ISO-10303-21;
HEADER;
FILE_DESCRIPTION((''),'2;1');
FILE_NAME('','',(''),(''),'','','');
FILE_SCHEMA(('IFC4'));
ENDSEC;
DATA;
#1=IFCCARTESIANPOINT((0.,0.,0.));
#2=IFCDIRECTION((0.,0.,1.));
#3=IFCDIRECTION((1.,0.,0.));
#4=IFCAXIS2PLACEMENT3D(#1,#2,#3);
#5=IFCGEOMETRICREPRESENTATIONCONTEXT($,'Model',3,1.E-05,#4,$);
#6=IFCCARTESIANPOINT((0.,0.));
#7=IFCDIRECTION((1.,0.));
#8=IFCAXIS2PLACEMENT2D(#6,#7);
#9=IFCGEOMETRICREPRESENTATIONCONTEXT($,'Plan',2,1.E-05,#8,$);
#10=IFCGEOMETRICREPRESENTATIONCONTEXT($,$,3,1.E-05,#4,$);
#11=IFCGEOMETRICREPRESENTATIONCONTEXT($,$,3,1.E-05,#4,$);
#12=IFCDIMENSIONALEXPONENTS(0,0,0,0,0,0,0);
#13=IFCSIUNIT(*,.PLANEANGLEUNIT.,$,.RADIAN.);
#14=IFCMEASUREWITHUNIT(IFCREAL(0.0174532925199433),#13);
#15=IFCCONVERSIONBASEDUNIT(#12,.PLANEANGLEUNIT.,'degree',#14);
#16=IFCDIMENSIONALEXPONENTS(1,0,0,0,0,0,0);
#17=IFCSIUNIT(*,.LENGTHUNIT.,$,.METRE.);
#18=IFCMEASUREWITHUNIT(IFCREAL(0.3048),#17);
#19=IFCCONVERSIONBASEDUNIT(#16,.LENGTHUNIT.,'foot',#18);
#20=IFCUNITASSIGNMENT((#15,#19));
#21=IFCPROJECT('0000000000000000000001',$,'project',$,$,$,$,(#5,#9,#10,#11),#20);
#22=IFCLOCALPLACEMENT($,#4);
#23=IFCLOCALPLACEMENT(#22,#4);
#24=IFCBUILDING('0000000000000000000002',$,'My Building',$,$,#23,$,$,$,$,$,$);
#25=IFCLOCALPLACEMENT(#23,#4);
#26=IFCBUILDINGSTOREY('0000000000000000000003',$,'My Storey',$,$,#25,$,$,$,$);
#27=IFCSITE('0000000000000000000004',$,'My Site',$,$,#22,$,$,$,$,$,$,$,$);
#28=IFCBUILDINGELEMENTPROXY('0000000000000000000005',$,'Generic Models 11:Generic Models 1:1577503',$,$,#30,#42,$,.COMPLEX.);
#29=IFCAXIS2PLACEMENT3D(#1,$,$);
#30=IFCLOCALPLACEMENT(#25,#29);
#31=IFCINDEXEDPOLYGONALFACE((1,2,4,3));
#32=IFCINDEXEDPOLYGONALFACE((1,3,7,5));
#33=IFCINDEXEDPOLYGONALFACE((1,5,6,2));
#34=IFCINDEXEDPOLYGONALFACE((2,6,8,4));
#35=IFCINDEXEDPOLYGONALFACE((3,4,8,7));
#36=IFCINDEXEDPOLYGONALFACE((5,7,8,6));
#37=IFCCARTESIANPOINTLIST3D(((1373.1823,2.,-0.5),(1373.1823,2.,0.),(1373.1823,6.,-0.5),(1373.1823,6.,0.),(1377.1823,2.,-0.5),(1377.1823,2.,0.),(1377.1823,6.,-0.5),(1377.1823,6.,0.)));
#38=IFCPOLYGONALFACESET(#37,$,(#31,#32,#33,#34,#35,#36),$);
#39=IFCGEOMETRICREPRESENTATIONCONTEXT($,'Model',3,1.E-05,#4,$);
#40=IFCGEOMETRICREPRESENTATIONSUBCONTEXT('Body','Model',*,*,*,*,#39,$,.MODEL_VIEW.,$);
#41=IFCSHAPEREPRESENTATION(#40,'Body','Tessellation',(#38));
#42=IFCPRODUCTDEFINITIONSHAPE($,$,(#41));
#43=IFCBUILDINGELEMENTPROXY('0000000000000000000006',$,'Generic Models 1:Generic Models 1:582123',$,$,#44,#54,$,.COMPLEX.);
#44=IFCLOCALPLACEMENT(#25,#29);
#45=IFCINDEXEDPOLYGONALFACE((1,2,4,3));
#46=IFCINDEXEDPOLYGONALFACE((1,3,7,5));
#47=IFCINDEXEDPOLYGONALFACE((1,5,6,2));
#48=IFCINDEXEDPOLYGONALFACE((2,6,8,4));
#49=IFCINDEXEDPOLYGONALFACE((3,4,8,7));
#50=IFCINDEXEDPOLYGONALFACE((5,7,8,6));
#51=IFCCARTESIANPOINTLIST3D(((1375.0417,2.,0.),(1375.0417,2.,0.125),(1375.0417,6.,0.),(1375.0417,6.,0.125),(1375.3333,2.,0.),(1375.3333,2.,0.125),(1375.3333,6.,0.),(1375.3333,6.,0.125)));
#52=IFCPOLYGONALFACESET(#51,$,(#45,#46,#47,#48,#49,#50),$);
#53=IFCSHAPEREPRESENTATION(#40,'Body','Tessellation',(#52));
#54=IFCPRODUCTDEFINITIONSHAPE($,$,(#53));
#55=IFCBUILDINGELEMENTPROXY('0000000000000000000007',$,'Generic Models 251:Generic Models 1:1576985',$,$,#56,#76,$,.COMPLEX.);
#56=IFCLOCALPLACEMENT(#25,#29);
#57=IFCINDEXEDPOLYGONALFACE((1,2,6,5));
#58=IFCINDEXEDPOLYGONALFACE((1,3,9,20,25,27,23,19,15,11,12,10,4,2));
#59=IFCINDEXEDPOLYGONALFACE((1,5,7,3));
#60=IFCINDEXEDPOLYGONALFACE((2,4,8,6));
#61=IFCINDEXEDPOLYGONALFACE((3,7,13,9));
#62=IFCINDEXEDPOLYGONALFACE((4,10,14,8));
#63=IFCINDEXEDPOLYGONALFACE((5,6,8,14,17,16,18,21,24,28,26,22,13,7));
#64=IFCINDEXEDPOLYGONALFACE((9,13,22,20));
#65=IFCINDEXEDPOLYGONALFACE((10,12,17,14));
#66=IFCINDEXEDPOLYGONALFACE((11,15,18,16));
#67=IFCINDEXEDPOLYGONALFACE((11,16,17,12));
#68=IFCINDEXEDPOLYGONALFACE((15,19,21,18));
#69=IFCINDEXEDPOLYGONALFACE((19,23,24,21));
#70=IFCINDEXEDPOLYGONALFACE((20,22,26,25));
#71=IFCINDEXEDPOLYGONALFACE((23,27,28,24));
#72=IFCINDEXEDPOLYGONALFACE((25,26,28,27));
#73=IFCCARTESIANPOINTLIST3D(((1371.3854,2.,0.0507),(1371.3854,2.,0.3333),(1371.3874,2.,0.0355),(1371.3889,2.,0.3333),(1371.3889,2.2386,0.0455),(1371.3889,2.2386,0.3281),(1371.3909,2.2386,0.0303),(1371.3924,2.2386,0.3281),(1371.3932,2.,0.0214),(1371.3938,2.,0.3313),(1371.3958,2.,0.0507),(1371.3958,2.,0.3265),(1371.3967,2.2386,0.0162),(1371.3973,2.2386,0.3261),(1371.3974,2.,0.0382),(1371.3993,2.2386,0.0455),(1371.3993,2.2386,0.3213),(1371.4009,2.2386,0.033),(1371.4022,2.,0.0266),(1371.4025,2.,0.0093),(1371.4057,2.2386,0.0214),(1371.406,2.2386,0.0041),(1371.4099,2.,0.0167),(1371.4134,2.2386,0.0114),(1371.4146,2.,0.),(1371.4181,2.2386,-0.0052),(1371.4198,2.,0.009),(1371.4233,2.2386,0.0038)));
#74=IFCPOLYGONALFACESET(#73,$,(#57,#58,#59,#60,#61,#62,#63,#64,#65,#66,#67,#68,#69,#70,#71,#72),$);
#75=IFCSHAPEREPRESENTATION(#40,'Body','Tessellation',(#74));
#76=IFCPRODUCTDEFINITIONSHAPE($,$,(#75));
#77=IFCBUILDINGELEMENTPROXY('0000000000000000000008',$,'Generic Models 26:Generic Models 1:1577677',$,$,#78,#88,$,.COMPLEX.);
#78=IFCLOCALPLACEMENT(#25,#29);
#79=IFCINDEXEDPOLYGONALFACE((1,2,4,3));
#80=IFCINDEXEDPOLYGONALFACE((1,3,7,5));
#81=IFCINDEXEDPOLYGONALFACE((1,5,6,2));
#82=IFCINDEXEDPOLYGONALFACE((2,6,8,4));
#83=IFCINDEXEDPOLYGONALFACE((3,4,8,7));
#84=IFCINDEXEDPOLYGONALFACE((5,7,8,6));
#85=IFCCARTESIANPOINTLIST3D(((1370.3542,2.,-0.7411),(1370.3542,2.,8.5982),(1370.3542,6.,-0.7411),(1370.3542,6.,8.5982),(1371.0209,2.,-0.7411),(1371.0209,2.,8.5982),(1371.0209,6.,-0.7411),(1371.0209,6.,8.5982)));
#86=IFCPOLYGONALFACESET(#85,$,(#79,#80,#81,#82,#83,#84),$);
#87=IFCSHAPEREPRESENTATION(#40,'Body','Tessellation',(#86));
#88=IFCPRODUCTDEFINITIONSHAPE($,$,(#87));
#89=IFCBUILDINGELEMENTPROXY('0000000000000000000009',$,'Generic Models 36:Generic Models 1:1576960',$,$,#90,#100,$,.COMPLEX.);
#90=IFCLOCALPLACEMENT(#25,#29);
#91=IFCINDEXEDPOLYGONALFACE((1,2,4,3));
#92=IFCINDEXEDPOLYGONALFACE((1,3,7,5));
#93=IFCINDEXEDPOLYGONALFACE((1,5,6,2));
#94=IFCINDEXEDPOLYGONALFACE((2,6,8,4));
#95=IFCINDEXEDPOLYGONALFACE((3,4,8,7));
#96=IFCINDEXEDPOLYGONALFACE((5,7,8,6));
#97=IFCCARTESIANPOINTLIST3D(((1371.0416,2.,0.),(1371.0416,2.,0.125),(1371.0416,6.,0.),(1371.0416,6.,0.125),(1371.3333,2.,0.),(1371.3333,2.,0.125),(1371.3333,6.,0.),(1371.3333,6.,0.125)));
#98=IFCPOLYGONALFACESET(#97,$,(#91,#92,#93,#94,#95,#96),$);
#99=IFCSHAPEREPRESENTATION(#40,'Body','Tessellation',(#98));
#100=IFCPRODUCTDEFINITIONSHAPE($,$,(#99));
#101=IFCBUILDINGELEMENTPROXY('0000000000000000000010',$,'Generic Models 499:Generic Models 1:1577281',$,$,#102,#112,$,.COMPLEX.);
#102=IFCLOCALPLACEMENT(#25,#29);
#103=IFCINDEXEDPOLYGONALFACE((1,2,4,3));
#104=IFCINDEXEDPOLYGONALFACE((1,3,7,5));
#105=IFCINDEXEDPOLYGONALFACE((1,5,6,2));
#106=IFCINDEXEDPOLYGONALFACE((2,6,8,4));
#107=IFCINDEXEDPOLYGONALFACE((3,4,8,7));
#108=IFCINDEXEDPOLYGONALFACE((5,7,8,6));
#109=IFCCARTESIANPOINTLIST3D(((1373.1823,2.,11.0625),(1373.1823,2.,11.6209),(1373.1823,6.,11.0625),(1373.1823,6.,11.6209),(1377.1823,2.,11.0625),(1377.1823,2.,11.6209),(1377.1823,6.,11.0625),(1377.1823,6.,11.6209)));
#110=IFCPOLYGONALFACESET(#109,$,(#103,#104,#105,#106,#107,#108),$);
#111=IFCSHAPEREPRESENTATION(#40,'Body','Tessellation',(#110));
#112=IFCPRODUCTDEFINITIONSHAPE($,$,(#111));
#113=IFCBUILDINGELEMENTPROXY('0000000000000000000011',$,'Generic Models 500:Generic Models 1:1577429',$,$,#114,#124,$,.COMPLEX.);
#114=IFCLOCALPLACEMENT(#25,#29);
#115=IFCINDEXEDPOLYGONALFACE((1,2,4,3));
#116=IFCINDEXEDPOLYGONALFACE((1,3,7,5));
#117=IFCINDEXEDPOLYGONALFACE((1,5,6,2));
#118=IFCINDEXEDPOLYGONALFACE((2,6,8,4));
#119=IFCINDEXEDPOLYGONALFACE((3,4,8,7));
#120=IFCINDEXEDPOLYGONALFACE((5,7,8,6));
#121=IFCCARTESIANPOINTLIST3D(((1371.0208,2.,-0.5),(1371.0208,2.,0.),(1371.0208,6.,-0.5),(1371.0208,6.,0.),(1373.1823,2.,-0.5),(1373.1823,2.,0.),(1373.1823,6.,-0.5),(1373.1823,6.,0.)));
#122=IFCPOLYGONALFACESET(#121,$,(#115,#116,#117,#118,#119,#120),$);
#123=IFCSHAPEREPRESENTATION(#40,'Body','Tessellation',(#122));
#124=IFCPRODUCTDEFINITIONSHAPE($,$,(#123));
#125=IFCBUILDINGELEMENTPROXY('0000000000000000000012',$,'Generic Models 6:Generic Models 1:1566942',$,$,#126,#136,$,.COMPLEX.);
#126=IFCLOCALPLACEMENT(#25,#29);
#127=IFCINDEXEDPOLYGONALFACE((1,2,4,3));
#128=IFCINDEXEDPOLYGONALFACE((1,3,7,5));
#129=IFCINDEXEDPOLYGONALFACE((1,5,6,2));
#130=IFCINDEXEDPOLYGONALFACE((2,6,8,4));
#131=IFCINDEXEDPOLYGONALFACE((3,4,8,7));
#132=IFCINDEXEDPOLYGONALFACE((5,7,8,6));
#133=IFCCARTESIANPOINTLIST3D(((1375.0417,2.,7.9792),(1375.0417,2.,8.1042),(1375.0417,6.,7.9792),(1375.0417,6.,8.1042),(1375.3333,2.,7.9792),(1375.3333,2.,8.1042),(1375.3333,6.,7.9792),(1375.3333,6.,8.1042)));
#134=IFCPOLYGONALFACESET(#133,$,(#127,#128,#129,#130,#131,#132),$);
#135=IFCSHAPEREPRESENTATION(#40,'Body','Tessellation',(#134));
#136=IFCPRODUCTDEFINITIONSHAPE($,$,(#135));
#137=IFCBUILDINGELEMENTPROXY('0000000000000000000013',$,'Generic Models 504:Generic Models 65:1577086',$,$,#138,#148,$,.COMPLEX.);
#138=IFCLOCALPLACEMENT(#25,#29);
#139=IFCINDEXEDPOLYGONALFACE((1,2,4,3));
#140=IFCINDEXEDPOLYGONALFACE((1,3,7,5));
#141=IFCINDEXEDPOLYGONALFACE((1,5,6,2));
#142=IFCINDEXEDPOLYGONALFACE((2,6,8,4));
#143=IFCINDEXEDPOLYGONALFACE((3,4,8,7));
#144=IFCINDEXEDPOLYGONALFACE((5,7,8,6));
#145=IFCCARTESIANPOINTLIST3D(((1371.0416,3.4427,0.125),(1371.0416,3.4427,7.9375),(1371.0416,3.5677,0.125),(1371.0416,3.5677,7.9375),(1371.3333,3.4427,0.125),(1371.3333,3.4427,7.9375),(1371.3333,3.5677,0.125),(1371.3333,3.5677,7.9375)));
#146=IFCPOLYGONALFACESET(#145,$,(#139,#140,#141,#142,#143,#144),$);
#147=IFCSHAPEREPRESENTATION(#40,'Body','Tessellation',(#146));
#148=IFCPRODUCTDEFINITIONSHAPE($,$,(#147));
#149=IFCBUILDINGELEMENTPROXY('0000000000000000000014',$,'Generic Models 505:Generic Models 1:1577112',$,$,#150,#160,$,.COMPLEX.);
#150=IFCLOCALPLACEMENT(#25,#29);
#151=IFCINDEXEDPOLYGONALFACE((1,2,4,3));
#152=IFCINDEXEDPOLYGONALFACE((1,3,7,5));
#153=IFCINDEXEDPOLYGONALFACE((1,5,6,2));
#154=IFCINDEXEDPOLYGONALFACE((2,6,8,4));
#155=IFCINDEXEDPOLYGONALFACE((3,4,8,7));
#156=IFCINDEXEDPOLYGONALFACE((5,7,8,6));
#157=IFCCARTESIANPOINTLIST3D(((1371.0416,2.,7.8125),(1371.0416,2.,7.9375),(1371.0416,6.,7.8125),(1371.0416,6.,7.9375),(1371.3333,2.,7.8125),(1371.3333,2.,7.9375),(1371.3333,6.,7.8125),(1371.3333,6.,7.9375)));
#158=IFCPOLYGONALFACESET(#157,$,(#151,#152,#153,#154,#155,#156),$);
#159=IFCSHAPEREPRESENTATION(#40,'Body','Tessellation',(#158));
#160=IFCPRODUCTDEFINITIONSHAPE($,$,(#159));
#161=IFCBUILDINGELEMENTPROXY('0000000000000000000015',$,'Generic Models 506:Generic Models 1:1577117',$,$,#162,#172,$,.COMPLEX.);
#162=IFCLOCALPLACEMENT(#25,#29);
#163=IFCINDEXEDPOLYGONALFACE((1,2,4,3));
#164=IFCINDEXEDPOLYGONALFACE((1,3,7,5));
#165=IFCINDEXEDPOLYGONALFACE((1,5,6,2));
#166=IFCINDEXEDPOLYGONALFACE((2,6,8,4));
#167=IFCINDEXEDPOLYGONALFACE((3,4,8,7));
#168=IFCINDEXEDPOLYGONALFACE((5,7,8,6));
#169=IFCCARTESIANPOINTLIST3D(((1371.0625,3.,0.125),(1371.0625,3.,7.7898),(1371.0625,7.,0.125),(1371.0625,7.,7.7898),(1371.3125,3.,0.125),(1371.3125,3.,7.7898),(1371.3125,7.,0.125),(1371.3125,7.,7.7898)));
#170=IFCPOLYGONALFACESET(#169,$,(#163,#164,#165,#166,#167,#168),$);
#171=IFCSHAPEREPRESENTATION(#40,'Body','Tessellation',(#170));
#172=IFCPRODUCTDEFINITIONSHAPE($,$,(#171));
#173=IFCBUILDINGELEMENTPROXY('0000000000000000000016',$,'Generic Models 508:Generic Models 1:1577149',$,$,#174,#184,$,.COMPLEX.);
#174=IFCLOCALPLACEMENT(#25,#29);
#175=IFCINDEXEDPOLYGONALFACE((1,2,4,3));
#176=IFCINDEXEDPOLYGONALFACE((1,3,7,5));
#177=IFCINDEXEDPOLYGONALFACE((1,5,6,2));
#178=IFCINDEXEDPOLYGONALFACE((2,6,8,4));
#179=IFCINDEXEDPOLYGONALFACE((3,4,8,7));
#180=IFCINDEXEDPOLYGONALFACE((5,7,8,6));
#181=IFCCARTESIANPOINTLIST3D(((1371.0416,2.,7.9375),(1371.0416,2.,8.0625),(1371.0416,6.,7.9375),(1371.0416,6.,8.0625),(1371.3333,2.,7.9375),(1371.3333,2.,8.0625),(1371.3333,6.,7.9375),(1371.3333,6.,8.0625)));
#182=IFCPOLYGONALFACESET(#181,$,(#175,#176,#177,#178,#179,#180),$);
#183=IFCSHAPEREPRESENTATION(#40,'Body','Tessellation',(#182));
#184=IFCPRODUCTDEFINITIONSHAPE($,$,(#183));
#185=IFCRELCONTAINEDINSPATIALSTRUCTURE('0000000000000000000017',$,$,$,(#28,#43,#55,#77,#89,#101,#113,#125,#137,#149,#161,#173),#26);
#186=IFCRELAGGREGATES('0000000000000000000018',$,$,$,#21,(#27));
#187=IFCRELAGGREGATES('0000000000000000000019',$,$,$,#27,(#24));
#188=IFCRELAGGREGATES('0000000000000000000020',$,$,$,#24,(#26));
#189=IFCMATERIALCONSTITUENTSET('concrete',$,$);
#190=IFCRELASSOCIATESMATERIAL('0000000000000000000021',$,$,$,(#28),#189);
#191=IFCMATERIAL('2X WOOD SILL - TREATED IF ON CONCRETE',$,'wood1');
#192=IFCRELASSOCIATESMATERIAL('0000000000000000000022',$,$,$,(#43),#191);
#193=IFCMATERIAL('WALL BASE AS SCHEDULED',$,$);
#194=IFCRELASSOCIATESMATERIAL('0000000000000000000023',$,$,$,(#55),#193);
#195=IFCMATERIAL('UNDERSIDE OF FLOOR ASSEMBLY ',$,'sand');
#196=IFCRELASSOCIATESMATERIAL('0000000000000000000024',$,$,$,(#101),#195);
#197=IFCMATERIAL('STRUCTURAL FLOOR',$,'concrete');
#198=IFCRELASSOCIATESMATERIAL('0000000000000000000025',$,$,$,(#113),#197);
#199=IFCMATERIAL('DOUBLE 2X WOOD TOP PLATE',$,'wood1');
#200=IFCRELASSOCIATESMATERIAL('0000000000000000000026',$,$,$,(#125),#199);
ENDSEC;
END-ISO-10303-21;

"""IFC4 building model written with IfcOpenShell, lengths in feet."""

from ifc_helpers import new_model, entity, si_unit, converted_unit, frame, origin_with_axes, origin_2d_with_axis, place, context, subcontext, project, spatial, polyline, line, indexed_curve, outline, extrude, material, constituent_set, element, save


model = new_model("IFC4")

# Units and contexts
model_context_1 = context("Model", 3, precision=1e-05, world=origin_with_axes())
plan_context = context("Plan", 2, precision=1e-05, world=origin_2d_with_axis())
model_context_2 = context("Model", 3, precision=1e-05, world=origin_with_axes())
context_of_model_1 = context(None, 3, precision=1e-05, world=origin_with_axes())
context_of_model_2 = context(None, 3, precision=1e-05, world=origin_with_axes())
body_context = subcontext(model_context_2, "Body", "Model", "MODEL_VIEW")
ifc_project = project(units=[converted_unit("PLANEANGLEUNIT", "degree", entity("IfcReal", 0.0174532925199433), si_unit("PLANEANGLEUNIT", "RADIAN"), dimensions=[0, 0, 0, 0, 0, 0, 0]), converted_unit("LENGTHUNIT", "foot", entity("IfcReal", 0.3048), si_unit("LENGTHUNIT", "METRE"), dimensions=[1, 0, 0, 0, 0, 0, 0])], contexts=[model_context_1, plan_context, context_of_model_1, context_of_model_2])

# Site, building, storey
site_placement = place(None, origin_with_axes())
site = spatial("IfcSite", under=ifc_project, at=site_placement, Name="My Site")
building_placement = place(site_placement, origin_with_axes())
building = spatial("IfcBuilding", under=site, at=building_placement, Name="My Building")
storey_placement = place(building_placement, origin_with_axes())
storey = spatial("IfcBuildingStorey", under=building, at=storey_placement, Name="My Storey")

# Building element proxies
ifc_constituent_set = constituent_set(Name="concrete")
proxy_1_placement = place(storey_placement, frame((1373.1823, 6.0, -0.5), z_axis=(0.0, -1.0, 0.0), x_axis=(0.0, 0.0, -1.0)))
element("IfcBuildingElementProxy", 1, at=proxy_1_placement, inside=storey, material=ifc_constituent_set, Name="Generic Models 11:Generic Models 1:1577503", PredefinedType="COMPLEX", context=body_context, shape_type="SweptSolid", body=[
    extrude(outline(polyline([(-0.25, -2.0), (0.25, -2.0), (0.25, 2.0), (-0.25, 2.0), (-0.25, -2.0)])), frame((-0.25, 2.0, 0.0), z_axis=(0.0, 0.0, -1.0), x_axis=(-1.0, 0.0, 0.0)), (0.0, 0.0, -1.0), 4.0),
])
ifc_material_1 = material(Name="2X WOOD SILL - TREATED IF ON CONCRETE", Category="wood1")
proxy_2_placement = place(storey_placement, frame((1375.0417, 6.0, 0.0), z_axis=(0.0, -1.0, 0.0), x_axis=(0.0, 0.0, -1.0)))
element("IfcBuildingElementProxy", 2, at=proxy_2_placement, inside=storey, material=ifc_material_1, Name="Generic Models 1:Generic Models 1:582123", PredefinedType="COMPLEX", context=body_context, shape_type="SweptSolid", body=[
    extrude(outline(polyline([(-0.0625, -0.1458), (0.0625, -0.1458), (0.0625, 0.1458), (-0.0625, 0.1458), (-0.0625, -0.1458)])), frame((-0.0625, 0.1458, 0.0), z_axis=(0.0, 0.0, -1.0), x_axis=(1.0, 0.0, 0.0)), (0.0, 0.0, -1.0), 4.0),
])
ifc_material_2 = material(Name="WALL BASE AS SCHEDULED")
proxy_3_placement = place(storey_placement, frame((1371.3854, 6.0, 0.0), z_axis=(0.0, -1.0, 0.0), x_axis=(0.0, 0.0, -1.0)))
element("IfcBuildingElementProxy", 3, at=proxy_3_placement, inside=storey, material=ifc_material_2, Name="Generic Models 251:Generic Models 1:1576985", PredefinedType="COMPLEX", context=body_context, shape_type="SweptSolid", body=[
    extrude(outline(polyline([(0.0971, 0.0), (0.1059, -0.009), (0.1142, -0.0027), (0.1035, 0.0082), (0.0904, 0.016), (0.0756, 0.02), (0.0603, 0.0202), (-0.2202, -0.0144), (-0.2197, -0.0179), (-0.2172, -0.0225), (-0.2121, -0.0239), (0.0616, 0.0098), (0.0742, 0.0097), (0.0863, 0.0064), (0.0971, 0.0)])), frame((-0.1078, 0.0161, 3.7614), z_axis=(-0.000001, 0.0, -1.0), x_axis=(0.992503, 0.122219, -0.000004)), (-0.023549, 0.011857, -0.999652), 0.2387),
])
proxy_4_placement = place(storey_placement, frame((1370.3542, 6.0, -0.7411), z_axis=(0.0, -1.0, 0.0), x_axis=(0.0, 0.0, -1.0)))
element("IfcBuildingElementProxy", 4, at=proxy_4_placement, inside=storey, Name="Generic Models 26:Generic Models 1:1577677", PredefinedType="COMPLEX", context=body_context, shape_type="SweptSolid", body=[
    extrude(outline(polyline([(-0.3333, -4.6697), (0.3333, -4.6697), (0.3333, 4.6697), (-0.3333, 4.6697), (-0.3333, -4.6697)])), frame((-4.6697, 0.3333, 0.0), z_axis=(0.0, 0.0, -1.0), x_axis=(0.0, -1.0, 0.0)), (0.0, 0.0, -1.0), 4.0),
])
proxy_5_placement = place(storey_placement, frame((1371.0416, 6.0, 0.0), z_axis=(0.0, -1.0, 0.0), x_axis=(0.0, 0.0, -1.0)))
element("IfcBuildingElementProxy", 5, at=proxy_5_placement, inside=storey, Name="Generic Models 36:Generic Models 1:1576960", PredefinedType="COMPLEX", context=body_context, shape_type="SweptSolid", body=[
    extrude(outline(polyline([(-0.0625, -0.1458), (0.0625, -0.1458), (0.0625, 0.1458), (-0.0625, 0.1458), (-0.0625, -0.1458)])), frame((-0.0625, 0.1458, 0.0), z_axis=(0.0, 0.0, -1.0), x_axis=(1.0, 0.0, 0.0)), (0.0, 0.0, -1.0), 4.0),
])
ifc_material_3 = material(Name="UNDERSIDE OF FLOOR ASSEMBLY ", Category="sand")
proxy_6_placement = place(storey_placement, frame((1373.1823, 6.0, 11.0625), z_axis=(0.0, -1.0, 0.0), x_axis=(0.0, 0.0, -1.0)))
element("IfcBuildingElementProxy", 6, at=proxy_6_placement, inside=storey, material=ifc_material_3, Name="Generic Models 499:Generic Models 1:1577281", PredefinedType="COMPLEX", context=body_context, shape_type="SweptSolid", body=[
    extrude(outline(indexed_curve([(-0.2792, -2.0), (0.2792, -2.0), (0.2792, 2.0), (-0.2792, 2.0)], segments=[line(3, 2), line(2, 1), line(1, 4), line(4, 3)], self_intersect=False)), frame((-0.2792, 2.0, 0.0), z_axis=(0.0, 0.0, -1.0), x_axis=(1.0, 0.0, 0.0)), (0.0, 0.0, -1.0), 4.0),
])
ifc_material_4 = material(Name="STRUCTURAL FLOOR", Category="concrete")
proxy_7_placement = place(storey_placement, frame((1371.0208, 6.0, -0.5), z_axis=(0.0, -1.0, 0.0), x_axis=(0.0, 0.0, -1.0)))
element("IfcBuildingElementProxy", 7, at=proxy_7_placement, inside=storey, material=ifc_material_4, Name="Generic Models 500:Generic Models 1:1577429", PredefinedType="COMPLEX", context=body_context, shape_type="SweptSolid", body=[
    extrude(outline(polyline([(-0.25, -1.0807), (0.25, -1.0807), (0.25, 1.0807), (-0.25, 1.0807), (-0.25, -1.0807)])), frame((-0.25, 1.0807, 0.0), z_axis=(0.0, 0.0, -1.0), x_axis=(1.0, 0.0, 0.0)), (0.0, 0.0, -1.0), 4.0),
])
ifc_material_5 = material(Name="DOUBLE 2X WOOD TOP PLATE", Category="wood1")
proxy_8_placement = place(storey_placement, frame((1375.0417, 6.0, 7.9792), z_axis=(0.0, -1.0, 0.0), x_axis=(0.0, 0.0, -1.0)))
element("IfcBuildingElementProxy", 8, at=proxy_8_placement, inside=storey, material=ifc_material_5, Name="Generic Models 6:Generic Models 1:1566942", PredefinedType="COMPLEX", context=body_context, shape_type="SweptSolid", body=[
    extrude(outline(indexed_curve([(-0.0625, -0.1458), (0.0625, -0.1458), (0.0625, 0.1458), (-0.0625, 0.1458)], segments=[line(3, 2), line(2, 1), line(1, 4), line(4, 3)], self_intersect=False)), frame((-0.0625, 0.1458, 0.0), z_axis=(0.0, 0.0, -1.0), x_axis=(-1.0, 0.0, 0.0)), (0.0, 0.0, -1.0), 4.0),
])
proxy_9_placement = place(storey_placement, frame((1371.0416, 3.4427, 0.125), z_axis=(1.0, 0.0, 0.0), x_axis=(0.0, 0.0, -1.0)))
element("IfcBuildingElementProxy", 9, at=proxy_9_placement, inside=storey, Name="Generic Models 504:Generic Models 65:1577086", PredefinedType="COMPLEX", context=body_context, shape_type="SweptSolid", body=[
    extrude(outline(polyline([(-3.9062, -0.0625), (3.9062, -0.0625), (3.9062, 0.0625), (-3.9062, 0.0625), (-3.9062, -0.0625)])), frame((-3.9062, 0.0625, 0.0), z_axis=(0.0, 0.0, -1.0), x_axis=(1.0, 0.0, 0.0)), (0.0, 0.0, -1.0), 0.2917),
])
proxy_10_placement = place(storey_placement, frame((1371.0416, 6.0, 7.8125), z_axis=(0.0, -1.0, 0.0), x_axis=(0.0, 0.0, -1.0)))
element("IfcBuildingElementProxy", 10, at=proxy_10_placement, inside=storey, Name="Generic Models 505:Generic Models 1:1577112", PredefinedType="COMPLEX", context=body_context, shape_type="SweptSolid", body=[
    extrude(outline(polyline([(-0.0625, -0.1458), (0.0625, -0.1458), (0.0625, 0.1458), (-0.0625, 0.1458), (-0.0625, -0.1458)])), frame((-0.0625, 0.1458, 0.0), z_axis=(0.0, 0.0, -1.0), x_axis=(1.0, 0.0, 0.0)), (0.0, 0.0, -1.0), 4.0),
])
proxy_11_placement = place(storey_placement, frame((1371.0625, 3.0, 0.125), z_axis=(0.0, 1.0, 0.0), x_axis=(0.0, 0.0, -1.0)))
element("IfcBuildingElementProxy", 11, at=proxy_11_placement, inside=storey, Name="Generic Models 506:Generic Models 1:1577117", PredefinedType="COMPLEX", context=body_context, shape_type="SweptSolid", body=[
    extrude(outline(polyline([(-3.8324, -0.125), (3.8324, -0.125), (3.8324, 0.125), (-3.8324, 0.125), (-3.8324, -0.125)])), frame((-3.8324, -0.125, 0.0), z_axis=(0.0, 0.0, -1.0), x_axis=(-1.0, 0.0, 0.0)), (0.0, 0.0, -1.0), 4.0),
])
proxy_12_placement = place(storey_placement, frame((1371.0416, 6.0, 7.9375), z_axis=(0.0, -1.0, 0.0), x_axis=(0.0, 0.0, -1.0)))
element("IfcBuildingElementProxy", 12, at=proxy_12_placement, inside=storey, Name="Generic Models 508:Generic Models 1:1577149", PredefinedType="COMPLEX", context=body_context, shape_type="SweptSolid", body=[
    extrude(outline(polyline([(-0.0625, -0.1458), (0.0625, -0.1458), (0.0625, 0.1458), (-0.0625, 0.1458), (-0.0625, -0.1458)])), frame((-0.0625, 0.1458, 0.0), z_axis=(0.0, 0.0, -1.0), x_axis=(1.0, 0.0, 0.0)), (0.0, 0.0, -1.0), 4.0),
])

save(model, "model.ifc")
